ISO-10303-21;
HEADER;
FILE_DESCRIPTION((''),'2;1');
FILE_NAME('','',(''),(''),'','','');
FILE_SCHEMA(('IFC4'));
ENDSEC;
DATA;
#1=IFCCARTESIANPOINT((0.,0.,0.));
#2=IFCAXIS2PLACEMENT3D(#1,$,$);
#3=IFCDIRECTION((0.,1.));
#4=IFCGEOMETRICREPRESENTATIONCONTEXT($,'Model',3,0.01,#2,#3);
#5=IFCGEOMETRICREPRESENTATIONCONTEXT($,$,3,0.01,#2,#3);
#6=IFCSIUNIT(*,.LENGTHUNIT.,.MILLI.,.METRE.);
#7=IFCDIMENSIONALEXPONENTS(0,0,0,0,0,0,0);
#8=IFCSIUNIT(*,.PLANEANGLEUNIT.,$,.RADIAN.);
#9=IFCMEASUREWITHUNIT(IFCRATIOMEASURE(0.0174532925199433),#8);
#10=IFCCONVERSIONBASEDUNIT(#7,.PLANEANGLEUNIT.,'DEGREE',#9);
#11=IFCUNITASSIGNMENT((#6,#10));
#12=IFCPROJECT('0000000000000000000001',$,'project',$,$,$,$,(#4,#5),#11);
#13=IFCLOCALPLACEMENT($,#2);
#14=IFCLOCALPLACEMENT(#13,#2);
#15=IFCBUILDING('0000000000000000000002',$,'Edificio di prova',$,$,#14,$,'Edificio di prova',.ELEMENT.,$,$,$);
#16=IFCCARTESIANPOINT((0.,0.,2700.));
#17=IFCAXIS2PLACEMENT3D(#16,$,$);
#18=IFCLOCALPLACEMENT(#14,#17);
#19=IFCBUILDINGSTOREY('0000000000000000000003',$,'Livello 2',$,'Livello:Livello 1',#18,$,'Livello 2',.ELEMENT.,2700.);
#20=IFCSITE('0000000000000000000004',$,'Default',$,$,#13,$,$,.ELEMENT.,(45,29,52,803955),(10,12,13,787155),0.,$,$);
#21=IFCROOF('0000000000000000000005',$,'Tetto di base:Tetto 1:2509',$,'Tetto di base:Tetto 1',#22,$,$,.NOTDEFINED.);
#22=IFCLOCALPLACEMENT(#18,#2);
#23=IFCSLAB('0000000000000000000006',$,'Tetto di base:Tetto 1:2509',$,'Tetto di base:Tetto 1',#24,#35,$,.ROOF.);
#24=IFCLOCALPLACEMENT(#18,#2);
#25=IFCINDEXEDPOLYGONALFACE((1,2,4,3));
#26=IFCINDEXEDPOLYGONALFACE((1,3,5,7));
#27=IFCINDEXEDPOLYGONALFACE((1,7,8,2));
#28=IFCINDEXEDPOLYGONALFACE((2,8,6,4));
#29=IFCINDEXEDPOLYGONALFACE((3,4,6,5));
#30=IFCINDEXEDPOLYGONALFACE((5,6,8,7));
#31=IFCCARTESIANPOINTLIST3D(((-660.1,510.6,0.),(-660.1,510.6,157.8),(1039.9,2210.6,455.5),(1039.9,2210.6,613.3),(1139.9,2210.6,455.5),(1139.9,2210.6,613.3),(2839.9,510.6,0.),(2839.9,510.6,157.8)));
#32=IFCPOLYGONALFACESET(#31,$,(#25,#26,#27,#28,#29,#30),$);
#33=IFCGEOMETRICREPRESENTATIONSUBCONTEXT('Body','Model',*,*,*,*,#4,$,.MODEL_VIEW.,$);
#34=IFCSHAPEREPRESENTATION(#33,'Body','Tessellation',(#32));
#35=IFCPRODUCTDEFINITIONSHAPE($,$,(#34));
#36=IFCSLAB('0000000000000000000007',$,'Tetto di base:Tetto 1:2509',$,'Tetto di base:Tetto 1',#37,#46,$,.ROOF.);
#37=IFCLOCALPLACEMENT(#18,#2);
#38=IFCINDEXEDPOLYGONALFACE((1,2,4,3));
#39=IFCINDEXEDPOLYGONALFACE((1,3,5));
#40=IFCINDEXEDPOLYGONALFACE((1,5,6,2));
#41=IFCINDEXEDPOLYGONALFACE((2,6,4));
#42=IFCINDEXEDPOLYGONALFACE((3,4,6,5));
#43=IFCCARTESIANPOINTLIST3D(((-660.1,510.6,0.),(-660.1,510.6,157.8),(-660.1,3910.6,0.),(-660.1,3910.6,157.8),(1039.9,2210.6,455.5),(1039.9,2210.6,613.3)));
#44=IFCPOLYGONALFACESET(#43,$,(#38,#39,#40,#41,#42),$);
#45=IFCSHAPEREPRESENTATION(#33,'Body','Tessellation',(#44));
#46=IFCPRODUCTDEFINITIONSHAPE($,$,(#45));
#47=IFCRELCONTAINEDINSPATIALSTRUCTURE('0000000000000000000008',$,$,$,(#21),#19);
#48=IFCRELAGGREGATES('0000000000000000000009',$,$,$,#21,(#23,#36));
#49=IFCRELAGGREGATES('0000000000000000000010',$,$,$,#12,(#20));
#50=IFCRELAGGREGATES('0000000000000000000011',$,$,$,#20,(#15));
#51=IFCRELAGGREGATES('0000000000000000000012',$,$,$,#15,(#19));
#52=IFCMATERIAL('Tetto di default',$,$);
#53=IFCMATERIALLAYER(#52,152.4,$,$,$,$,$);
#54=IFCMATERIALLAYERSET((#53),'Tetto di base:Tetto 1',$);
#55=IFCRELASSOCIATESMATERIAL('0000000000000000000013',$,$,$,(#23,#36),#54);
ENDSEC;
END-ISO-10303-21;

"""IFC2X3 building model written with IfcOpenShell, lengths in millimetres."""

from ifc_helpers import new_model, entity, si_unit, converted_unit, direction, frame, origin, place, context, subcontext, project, spatial, polyline, outline, extrude, material, layer, layer_set, element, aggregate, save


model = new_model("IFC2X3")

# Units and contexts
model_context = context("Model", 3, precision=0.01, world=origin(), true_north=direction((0.0, 1.0)))
context_of_model = context(None, 3, precision=0.01, world=origin(), true_north=direction((0.0, 1.0)))
body_context = subcontext(model_context, "Body", "Model", "MODEL_VIEW")
ifc_project = project(units=[si_unit("LENGTHUNIT", "METRE", prefix="MILLI"), converted_unit("PLANEANGLEUNIT", "DEGREE", entity("IfcRatioMeasure", 0.0174532925199433), si_unit("PLANEANGLEUNIT", "RADIAN"), dimensions=[0, 0, 0, 0, 0, 0, 0])], contexts=[model_context, context_of_model])

# Site, building, storey
site_placement = place(None, origin())
site = spatial("IfcSite", under=ifc_project, at=site_placement, Name="Default", CompositionType="ELEMENT", RefLatitude=(45, 29, 52, 803955), RefLongitude=(10, 12, 13, 787155), RefElevation=0.0)
building_placement = place(site_placement, origin())
building = spatial("IfcBuilding", under=site, at=building_placement, Name="Edificio di prova", LongName="Edificio di prova", CompositionType="ELEMENT")
storey_placement = place(building_placement, frame((0.0, 0.0, 2700.0)))
storey = spatial("IfcBuildingStorey", under=building, at=storey_placement, Name="Livello 2", ObjectType="Livello:Livello 1", LongName="Livello 2", CompositionType="ELEMENT", Elevation=2700.0)

# Roof, slabs
roof_placement = place(storey_placement, frame((-660.1, 510.6, 0.0)))
roof = element("IfcRoof", 1, at=roof_placement, inside=storey, Name="Tetto di base:Tetto 1:2509", ObjectType="Tetto di base:Tetto 1", ShapeType="NOTDEFINED")
ifc_material = material(Name="Tetto di default")
ifc_layer = layer(ifc_material, 152.4)
ifc_layer_set = layer_set([ifc_layer], Name="Tetto di base:Tetto 1")
slab_1_placement = place(roof_placement, origin())
slab_1 = element("IfcSlab", 2, at=slab_1_placement, material=ifc_layer_set, Name="Tetto di base:Tetto 1:2509", ObjectType="Tetto di base:Tetto 1", PredefinedType="ROOF", context=body_context, shape_type="SweptSolid", body=[
    extrude(outline(polyline([(-1750.0, -880.0), (1750.0, -880.0), (50.0, 880.0), (-50.0, 880.0), (-1750.0, -880.0)])), frame((1750.0, 850.0, 227.8), z_axis=(0.0, -0.258819, 0.965926), x_axis=(1.0, 0.0, 0.0)), (0.0, 0.258819, 0.965926), 157.8),
])
slab_2_placement = place(roof_placement, origin())
slab_2 = element("IfcSlab", 3, at=slab_2_placement, material=ifc_layer_set, Name="Tetto di base:Tetto 1:2509", ObjectType="Tetto di base:Tetto 1", PredefinedType="ROOF", context=body_context, shape_type="SweptSolid", body=[
    extrude(outline(polyline([(-880.0, 1700.0), (-880.0, -1700.0), (880.0, 0.0), (-880.0, 1700.0)])), frame((850.0, 1700.0, 227.8), z_axis=(-0.258819, 0.0, 0.965926), x_axis=(0.965926, 0.0, 0.258819)), (0.258819, 0.0, 0.965926), 157.8),
])
aggregate(roof, [slab_1, slab_2])

save(model, "model.ifc")
